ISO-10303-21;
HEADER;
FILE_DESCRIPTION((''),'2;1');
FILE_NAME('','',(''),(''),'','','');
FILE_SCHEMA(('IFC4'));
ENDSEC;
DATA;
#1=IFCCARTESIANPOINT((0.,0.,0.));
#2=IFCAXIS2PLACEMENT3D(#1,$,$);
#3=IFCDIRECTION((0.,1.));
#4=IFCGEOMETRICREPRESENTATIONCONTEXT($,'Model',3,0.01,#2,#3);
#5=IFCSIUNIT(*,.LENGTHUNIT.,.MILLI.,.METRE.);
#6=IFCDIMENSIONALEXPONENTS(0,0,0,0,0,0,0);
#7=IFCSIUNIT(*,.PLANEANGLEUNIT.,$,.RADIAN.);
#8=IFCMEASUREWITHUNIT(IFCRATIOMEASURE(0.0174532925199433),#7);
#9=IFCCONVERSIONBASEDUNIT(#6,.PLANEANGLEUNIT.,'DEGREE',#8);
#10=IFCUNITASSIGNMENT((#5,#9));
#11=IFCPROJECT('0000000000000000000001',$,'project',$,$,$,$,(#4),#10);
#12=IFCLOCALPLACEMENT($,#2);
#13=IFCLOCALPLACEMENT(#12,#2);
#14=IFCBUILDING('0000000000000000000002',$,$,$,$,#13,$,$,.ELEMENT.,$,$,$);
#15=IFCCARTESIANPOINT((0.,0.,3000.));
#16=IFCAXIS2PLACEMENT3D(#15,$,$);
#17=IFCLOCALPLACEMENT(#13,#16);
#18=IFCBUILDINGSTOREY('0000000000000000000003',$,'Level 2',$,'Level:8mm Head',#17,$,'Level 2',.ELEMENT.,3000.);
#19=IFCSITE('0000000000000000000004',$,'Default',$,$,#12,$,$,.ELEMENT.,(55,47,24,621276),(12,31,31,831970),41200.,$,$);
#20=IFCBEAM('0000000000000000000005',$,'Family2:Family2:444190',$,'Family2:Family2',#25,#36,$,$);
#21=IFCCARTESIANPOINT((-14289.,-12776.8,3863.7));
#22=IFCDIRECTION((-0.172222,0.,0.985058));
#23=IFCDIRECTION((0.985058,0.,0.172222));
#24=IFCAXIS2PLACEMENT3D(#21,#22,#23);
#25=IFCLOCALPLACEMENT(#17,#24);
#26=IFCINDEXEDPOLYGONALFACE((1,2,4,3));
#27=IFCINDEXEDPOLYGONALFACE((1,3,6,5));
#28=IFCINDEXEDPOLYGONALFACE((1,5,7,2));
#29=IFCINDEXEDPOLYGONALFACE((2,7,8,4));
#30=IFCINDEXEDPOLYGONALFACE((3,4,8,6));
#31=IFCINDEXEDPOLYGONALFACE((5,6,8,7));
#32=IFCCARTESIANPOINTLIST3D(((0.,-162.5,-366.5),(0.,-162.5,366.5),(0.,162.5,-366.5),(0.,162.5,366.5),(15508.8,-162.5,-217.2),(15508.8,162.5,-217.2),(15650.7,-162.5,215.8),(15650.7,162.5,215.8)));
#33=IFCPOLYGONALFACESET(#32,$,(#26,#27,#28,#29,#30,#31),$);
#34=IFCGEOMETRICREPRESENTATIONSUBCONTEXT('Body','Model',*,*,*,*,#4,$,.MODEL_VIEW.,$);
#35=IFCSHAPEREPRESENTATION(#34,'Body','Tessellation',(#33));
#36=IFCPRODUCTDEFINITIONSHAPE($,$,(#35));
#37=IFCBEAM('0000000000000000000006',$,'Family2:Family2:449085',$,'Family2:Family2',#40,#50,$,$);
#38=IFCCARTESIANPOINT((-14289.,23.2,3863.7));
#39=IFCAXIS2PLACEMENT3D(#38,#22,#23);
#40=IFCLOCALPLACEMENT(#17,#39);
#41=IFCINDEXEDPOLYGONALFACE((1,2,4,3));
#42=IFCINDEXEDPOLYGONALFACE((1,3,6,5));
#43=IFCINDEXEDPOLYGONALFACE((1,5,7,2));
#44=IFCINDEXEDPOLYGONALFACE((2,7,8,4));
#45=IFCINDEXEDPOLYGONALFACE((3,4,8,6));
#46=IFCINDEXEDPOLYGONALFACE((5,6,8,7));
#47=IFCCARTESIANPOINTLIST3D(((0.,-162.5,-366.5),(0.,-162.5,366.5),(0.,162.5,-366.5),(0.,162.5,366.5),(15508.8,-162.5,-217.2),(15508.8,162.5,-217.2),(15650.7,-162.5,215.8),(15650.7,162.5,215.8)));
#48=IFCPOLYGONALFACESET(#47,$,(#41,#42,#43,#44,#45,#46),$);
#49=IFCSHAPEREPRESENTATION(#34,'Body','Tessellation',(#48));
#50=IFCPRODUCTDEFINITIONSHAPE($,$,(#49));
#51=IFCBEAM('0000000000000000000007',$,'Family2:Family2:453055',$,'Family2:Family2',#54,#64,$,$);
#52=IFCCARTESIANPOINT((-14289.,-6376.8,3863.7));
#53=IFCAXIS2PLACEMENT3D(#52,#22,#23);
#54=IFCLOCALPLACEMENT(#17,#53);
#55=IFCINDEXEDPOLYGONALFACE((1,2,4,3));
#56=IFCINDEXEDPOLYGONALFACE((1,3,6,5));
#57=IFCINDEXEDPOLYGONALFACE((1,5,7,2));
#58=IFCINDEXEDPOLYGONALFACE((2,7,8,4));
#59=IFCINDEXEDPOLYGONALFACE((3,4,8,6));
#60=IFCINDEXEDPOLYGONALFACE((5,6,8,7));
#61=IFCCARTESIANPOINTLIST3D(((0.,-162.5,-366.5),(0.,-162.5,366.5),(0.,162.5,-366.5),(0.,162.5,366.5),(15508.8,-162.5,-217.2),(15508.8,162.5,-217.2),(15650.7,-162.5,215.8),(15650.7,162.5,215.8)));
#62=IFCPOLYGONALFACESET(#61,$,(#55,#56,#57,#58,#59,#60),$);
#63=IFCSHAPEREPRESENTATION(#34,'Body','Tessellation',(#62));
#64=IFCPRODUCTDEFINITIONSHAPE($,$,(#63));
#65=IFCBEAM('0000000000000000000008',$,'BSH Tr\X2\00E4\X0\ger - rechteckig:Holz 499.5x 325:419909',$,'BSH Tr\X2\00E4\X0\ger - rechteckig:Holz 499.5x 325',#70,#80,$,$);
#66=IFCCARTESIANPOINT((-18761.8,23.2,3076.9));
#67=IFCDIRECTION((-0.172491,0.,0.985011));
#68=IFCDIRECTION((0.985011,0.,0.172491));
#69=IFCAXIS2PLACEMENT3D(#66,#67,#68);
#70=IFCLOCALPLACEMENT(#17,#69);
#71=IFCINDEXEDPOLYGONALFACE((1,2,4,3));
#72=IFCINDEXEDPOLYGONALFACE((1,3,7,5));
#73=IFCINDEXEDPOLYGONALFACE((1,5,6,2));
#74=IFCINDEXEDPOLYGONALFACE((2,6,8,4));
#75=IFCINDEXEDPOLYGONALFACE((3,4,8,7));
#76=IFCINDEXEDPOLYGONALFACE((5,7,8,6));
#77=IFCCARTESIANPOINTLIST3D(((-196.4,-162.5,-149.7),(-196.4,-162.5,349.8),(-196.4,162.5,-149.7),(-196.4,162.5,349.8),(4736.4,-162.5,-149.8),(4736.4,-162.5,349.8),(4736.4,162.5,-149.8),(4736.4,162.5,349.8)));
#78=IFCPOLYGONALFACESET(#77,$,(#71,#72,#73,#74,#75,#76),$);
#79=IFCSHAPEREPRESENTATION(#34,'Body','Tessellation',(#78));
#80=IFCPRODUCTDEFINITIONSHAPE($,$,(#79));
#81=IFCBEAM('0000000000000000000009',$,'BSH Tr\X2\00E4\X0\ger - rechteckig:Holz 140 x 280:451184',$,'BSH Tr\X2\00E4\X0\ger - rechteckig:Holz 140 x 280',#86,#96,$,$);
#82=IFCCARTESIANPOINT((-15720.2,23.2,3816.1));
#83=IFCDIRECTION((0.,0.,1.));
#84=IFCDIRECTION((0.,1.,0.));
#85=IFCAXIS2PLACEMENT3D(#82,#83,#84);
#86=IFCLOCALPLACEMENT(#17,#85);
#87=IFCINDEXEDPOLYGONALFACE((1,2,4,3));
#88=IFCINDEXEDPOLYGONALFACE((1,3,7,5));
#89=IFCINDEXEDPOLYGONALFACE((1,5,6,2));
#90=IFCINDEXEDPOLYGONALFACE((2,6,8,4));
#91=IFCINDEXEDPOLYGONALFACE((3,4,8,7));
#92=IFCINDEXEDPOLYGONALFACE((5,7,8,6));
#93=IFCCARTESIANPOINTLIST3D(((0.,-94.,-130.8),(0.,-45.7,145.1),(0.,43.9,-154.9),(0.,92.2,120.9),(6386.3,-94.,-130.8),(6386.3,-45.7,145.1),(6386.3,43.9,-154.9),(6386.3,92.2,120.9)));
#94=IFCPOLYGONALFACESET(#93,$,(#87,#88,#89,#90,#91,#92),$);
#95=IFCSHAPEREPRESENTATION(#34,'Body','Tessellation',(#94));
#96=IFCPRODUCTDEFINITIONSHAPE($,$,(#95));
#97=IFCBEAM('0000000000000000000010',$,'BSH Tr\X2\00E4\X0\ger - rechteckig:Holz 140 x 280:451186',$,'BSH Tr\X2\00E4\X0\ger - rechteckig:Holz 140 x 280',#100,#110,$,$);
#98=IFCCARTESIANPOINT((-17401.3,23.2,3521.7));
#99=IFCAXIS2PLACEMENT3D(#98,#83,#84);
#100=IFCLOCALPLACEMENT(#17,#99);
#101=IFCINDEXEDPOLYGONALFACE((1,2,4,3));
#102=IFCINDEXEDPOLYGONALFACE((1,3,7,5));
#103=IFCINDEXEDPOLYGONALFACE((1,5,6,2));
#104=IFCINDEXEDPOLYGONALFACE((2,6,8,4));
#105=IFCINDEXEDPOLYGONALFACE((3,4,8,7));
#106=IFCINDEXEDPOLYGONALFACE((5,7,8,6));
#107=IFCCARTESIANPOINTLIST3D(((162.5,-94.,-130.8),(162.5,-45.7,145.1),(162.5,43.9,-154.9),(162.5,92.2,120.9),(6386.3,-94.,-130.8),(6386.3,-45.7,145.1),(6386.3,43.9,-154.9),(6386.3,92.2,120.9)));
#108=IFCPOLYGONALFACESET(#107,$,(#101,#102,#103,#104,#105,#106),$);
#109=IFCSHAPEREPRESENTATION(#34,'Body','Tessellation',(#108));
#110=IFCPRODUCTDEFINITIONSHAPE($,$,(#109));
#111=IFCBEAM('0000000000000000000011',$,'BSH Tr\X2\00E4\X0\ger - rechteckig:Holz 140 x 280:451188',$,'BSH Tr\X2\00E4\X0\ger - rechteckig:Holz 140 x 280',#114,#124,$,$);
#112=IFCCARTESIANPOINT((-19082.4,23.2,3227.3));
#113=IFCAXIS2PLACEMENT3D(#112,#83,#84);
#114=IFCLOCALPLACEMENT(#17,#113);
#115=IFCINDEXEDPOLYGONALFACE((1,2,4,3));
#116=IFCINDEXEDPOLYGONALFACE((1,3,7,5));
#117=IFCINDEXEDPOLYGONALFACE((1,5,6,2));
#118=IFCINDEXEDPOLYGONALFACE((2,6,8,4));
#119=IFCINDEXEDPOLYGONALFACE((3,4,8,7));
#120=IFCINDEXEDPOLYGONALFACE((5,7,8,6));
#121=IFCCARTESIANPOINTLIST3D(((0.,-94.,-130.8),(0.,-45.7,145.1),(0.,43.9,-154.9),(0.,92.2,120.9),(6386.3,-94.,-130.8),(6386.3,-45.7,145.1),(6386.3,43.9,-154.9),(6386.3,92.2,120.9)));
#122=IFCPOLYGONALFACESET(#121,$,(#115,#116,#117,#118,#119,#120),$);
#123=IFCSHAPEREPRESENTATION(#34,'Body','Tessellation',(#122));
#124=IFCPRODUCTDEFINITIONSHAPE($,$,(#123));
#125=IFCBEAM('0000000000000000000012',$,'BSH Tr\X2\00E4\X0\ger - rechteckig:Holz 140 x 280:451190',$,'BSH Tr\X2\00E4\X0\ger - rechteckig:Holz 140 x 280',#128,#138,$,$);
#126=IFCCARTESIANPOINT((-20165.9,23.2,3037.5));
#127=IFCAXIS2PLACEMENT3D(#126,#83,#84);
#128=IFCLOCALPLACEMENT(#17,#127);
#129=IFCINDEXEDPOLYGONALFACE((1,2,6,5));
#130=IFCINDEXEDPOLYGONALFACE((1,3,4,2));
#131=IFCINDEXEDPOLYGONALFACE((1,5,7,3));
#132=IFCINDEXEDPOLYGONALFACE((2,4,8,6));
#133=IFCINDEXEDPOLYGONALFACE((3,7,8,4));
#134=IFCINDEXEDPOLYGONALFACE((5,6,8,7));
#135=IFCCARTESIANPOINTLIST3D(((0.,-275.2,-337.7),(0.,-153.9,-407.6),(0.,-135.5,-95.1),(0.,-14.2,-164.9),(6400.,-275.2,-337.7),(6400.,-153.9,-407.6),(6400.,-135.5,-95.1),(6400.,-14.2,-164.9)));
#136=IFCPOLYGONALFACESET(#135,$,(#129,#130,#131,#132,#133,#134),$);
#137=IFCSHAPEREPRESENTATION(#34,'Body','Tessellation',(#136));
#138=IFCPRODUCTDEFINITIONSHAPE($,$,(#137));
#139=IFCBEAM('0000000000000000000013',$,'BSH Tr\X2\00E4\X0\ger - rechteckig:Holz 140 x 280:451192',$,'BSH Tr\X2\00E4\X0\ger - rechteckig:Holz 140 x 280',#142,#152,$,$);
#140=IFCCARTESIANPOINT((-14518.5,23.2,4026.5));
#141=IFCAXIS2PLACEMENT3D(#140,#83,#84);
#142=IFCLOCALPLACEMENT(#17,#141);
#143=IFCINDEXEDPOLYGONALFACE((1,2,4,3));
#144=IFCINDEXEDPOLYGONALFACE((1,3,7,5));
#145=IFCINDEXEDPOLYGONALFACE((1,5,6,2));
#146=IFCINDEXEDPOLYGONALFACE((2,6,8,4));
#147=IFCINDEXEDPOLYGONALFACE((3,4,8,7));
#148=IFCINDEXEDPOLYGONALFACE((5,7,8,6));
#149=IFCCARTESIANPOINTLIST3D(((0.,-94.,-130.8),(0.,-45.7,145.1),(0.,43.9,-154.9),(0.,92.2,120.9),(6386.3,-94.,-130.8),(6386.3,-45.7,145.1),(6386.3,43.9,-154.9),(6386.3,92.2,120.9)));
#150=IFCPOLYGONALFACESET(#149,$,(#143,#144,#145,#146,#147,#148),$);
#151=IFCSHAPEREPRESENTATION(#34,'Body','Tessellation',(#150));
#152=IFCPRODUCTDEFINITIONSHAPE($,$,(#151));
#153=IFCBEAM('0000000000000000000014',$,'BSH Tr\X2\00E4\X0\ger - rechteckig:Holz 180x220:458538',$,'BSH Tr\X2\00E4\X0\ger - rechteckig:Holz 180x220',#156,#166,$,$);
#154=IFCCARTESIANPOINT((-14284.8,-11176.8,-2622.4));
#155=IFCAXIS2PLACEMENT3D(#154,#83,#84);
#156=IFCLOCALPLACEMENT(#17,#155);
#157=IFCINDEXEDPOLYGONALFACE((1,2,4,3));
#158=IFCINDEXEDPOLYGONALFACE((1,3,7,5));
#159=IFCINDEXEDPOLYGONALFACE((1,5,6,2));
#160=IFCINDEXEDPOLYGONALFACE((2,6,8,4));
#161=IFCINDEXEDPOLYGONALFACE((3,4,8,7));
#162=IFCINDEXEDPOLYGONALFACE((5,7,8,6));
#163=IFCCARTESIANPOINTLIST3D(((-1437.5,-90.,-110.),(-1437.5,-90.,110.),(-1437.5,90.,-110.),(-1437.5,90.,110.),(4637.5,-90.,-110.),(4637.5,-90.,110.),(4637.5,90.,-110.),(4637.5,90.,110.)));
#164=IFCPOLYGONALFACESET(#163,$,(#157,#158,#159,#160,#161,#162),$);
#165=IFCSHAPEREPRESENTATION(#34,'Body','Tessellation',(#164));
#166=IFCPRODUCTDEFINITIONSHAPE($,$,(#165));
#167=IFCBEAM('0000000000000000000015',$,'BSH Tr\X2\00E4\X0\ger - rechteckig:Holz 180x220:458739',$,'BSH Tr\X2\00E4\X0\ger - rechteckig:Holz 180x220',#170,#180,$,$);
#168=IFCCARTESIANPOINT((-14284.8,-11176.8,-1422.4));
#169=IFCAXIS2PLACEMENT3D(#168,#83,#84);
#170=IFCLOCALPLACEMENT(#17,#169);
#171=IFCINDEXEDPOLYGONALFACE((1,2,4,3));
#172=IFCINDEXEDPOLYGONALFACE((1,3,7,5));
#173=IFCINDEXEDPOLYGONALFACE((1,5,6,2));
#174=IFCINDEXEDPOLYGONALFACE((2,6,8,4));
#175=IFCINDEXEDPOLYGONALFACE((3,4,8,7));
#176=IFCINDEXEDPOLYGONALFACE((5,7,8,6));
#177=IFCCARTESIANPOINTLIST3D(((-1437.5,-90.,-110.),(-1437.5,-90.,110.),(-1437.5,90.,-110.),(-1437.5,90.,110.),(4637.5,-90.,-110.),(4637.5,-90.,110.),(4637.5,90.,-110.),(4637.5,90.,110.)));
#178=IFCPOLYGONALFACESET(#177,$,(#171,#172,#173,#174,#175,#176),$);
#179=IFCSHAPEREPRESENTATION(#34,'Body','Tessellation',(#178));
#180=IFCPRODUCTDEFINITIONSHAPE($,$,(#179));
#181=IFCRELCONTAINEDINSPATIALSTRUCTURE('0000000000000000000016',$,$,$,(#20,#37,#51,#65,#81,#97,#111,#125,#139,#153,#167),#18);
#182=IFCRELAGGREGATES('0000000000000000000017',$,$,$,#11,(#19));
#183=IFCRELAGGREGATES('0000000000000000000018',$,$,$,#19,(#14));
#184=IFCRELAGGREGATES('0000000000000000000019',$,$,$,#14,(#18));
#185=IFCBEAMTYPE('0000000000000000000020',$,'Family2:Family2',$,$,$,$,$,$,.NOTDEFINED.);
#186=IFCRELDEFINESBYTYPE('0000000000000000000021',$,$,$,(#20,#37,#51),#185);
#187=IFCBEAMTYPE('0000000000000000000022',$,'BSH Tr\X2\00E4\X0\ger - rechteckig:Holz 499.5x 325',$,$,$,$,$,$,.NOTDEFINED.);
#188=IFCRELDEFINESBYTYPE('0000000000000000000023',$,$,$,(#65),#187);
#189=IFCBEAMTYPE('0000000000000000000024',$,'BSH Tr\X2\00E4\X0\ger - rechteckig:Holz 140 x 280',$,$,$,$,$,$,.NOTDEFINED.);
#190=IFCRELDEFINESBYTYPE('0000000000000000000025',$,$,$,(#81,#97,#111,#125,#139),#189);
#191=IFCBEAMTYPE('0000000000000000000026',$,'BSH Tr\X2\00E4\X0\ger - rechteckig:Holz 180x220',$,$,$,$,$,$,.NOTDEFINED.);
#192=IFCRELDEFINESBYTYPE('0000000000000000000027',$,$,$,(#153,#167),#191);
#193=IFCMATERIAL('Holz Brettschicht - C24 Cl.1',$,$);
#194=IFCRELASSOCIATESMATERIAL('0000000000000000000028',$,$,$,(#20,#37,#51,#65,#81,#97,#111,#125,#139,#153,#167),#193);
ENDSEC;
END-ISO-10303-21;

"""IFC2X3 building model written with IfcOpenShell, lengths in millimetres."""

from ifc_helpers import new_model, entity, si_unit, converted_unit, direction, frame, frame_2d, origin, origin_2d_with_axis, place, context, subcontext, project, spatial, polyline, rectangle, extrude, clip, bounded_halfspace, material, type_object, element, save


model = new_model("IFC2X3")

# Units and contexts
model_context = context("Model", 3, precision=0.01, world=origin(), true_north=direction((0.0, 1.0)))
body_context = subcontext(model_context, "Body", "Model", "MODEL_VIEW")
ifc_project = project(units=[si_unit("LENGTHUNIT", "METRE", prefix="MILLI"), converted_unit("PLANEANGLEUNIT", "DEGREE", entity("IfcRatioMeasure", 0.0174532925199433), si_unit("PLANEANGLEUNIT", "RADIAN"), dimensions=[0, 0, 0, 0, 0, 0, 0])], contexts=[model_context])

# Site, building, storey
site_placement = place(None, origin())
site = spatial("IfcSite", under=ifc_project, at=site_placement, Name="Default", CompositionType="ELEMENT", RefLatitude=(55, 47, 24, 621276), RefLongitude=(12, 31, 31, 831970), RefElevation=41200.0)
building_placement = place(site_placement, origin())
building = spatial("IfcBuilding", under=site, at=building_placement, CompositionType="ELEMENT")
storey_placement = place(building_placement, frame((0.0, 0.0, 3000.0)))
storey = spatial("IfcBuildingStorey", under=building, at=storey_placement, Name="Level 2", ObjectType="Level:8mm Head", LongName="Level 2", CompositionType="ELEMENT", Elevation=3000.0)

# Beams
ifc_material = material(Name="Holz Brettschicht - C24 Cl.1")
beam_type_1 = type_object("IfcBeamType", Name="Family2:Family2", PredefinedType="NOTDEFINED")
beam_1_placement = place(storey_placement, frame((-14289.0, -12776.8, 3863.7), z_axis=(-0.172222, 0.0, 0.985058), x_axis=(0.985058, 0.0, 0.172222)))
element("IfcBeam", 1, at=beam_1_placement, inside=storey, type_object=beam_type_1, material=ifc_material, Name="Family2:Family2:444190", ObjectType="Family2:Family2", context=body_context, shape_type="Clipping", body=[
    clip(clip(clip(extrude(rectangle(XDim=733.0, YDim=325.0, at=frame_2d((0.0, 0.0), x_axis=(0.0, 1.0))), frame((0.0, 0.0, 0.0), z_axis=(1.0, 0.0, 0.0), x_axis=(0.0, 1.0, 0.0)), (0.0, 0.0, 1.0), 15650.7), bounded_halfspace(frame((0.0, 0.0, -366.5), z_axis=(0.009627, 0.0, -0.999954), x_axis=(0.0, 1.0, 0.0)), False, frame((0.0, 0.0, 0.0), z_axis=(1.0, 0.0, 0.0), x_axis=(0.0, 1.0, 0.0)), polyline([(-162.5, -366.5), (162.5, -366.5), (162.5, -217.2), (-162.5, -217.2), (-162.5, -366.5)]))), bounded_halfspace(frame((15700.1, 0.0, 366.5), z_axis=(0.95028, 0.0, -0.311395), x_axis=(0.311395, 0.0, 0.95028)), False, frame((0.0, 0.0, 0.0), z_axis=(1.0, 0.0, 0.0), x_axis=(0.0, 1.0, 0.0)), polyline([(-162.5, 215.8), (-162.5, -217.2), (162.5, -217.2), (162.5, 215.8), (-162.5, 215.8)]))), bounded_halfspace(frame((0.0, 0.0, 366.5), z_axis=(0.009627, 0.0, 0.999954), x_axis=(0.0, -1.0, 0.0)), False, frame((0.0, 0.0, 0.0), z_axis=(1.0, 0.0, 0.0), x_axis=(0.0, 1.0, 0.0)), polyline([(162.5, 366.5), (-162.5, 366.5), (-162.5, 215.8), (162.5, 215.8), (162.5, 366.5)]))),
])
beam_2_placement = place(storey_placement, frame((-14289.0, 23.2, 3863.7), z_axis=(-0.172222, 0.0, 0.985058), x_axis=(0.985058, 0.0, 0.172222)))
element("IfcBeam", 2, at=beam_2_placement, inside=storey, type_object=beam_type_1, material=ifc_material, Name="Family2:Family2:449085", ObjectType="Family2:Family2", context=body_context, shape_type="Clipping", body=[
    clip(clip(clip(extrude(rectangle(XDim=733.0, YDim=325.0, at=frame_2d((0.0, 0.0), x_axis=(0.0, 1.0))), frame((0.0, 0.0, 0.0), z_axis=(1.0, 0.0, 0.0), x_axis=(0.0, 1.0, 0.0)), (0.0, 0.0, 1.0), 15650.7), bounded_halfspace(frame((0.0, 0.0, -366.5), z_axis=(0.009627, 0.0, -0.999954), x_axis=(0.0, 1.0, 0.0)), False, frame((0.0, 0.0, 0.0), z_axis=(1.0, 0.0, 0.0), x_axis=(0.0, 1.0, 0.0)), polyline([(-162.5, -366.5), (162.5, -366.5), (162.5, -217.2), (-162.5, -217.2), (-162.5, -366.5)]))), bounded_halfspace(frame((15700.1, 0.0, 366.5), z_axis=(0.95028, 0.0, -0.311395), x_axis=(0.311395, 0.0, 0.95028)), False, frame((0.0, 0.0, 0.0), z_axis=(1.0, 0.0, 0.0), x_axis=(0.0, 1.0, 0.0)), polyline([(-162.5, 215.8), (-162.5, -217.2), (162.5, -217.2), (162.5, 215.8), (-162.5, 215.8)]))), bounded_halfspace(frame((0.0, 0.0, 366.5), z_axis=(0.009627, 0.0, 0.999954), x_axis=(0.0, -1.0, 0.0)), False, frame((0.0, 0.0, 0.0), z_axis=(1.0, 0.0, 0.0), x_axis=(0.0, 1.0, 0.0)), polyline([(162.5, 366.5), (-162.5, 366.5), (-162.5, 215.8), (162.5, 215.8), (162.5, 366.5)]))),
])
beam_3_placement = place(storey_placement, frame((-14289.0, -6376.8, 3863.7), z_axis=(-0.172222, 0.0, 0.985058), x_axis=(0.985058, 0.0, 0.172222)))
element("IfcBeam", 3, at=beam_3_placement, inside=storey, type_object=beam_type_1, material=ifc_material, Name="Family2:Family2:453055", ObjectType="Family2:Family2", context=body_context, shape_type="Clipping", body=[
    clip(clip(clip(extrude(rectangle(XDim=733.0, YDim=325.0, at=frame_2d((0.0, 0.0), x_axis=(0.0, 1.0))), frame((0.0, 0.0, 0.0), z_axis=(1.0, 0.0, 0.0), x_axis=(0.0, 1.0, 0.0)), (0.0, 0.0, 1.0), 15650.7), bounded_halfspace(frame((0.0, 0.0, -366.5), z_axis=(0.009627, 0.0, -0.999954), x_axis=(0.0, 1.0, 0.0)), False, frame((0.0, 0.0, 0.0), z_axis=(1.0, 0.0, 0.0), x_axis=(0.0, 1.0, 0.0)), polyline([(-162.5, -366.5), (162.5, -366.5), (162.5, -217.2), (-162.5, -217.2), (-162.5, -366.5)]))), bounded_halfspace(frame((15700.1, 0.0, 366.5), z_axis=(0.95028, 0.0, -0.311395), x_axis=(0.311395, 0.0, 0.95028)), False, frame((0.0, 0.0, 0.0), z_axis=(1.0, 0.0, 0.0), x_axis=(0.0, 1.0, 0.0)), polyline([(-162.5, 215.8), (-162.5, -217.2), (162.5, -217.2), (162.5, 215.8), (-162.5, 215.8)]))), bounded_halfspace(frame((0.0, 0.0, 366.5), z_axis=(0.009627, 0.0, 0.999954), x_axis=(0.0, -1.0, 0.0)), False, frame((0.0, 0.0, 0.0), z_axis=(1.0, 0.0, 0.0), x_axis=(0.0, 1.0, 0.0)), polyline([(162.5, 366.5), (-162.5, 366.5), (-162.5, 215.8), (162.5, 215.8), (162.5, 366.5)]))),
])
beam_type_2 = type_object("IfcBeamType", Name="BSH Träger - rechteckig:Holz 499.5x 325", PredefinedType="NOTDEFINED")
beam_4_placement = place(storey_placement, frame((-18761.8, 23.2, 3076.9), z_axis=(-0.172491, 0.0, 0.985011), x_axis=(0.985011, 0.0, 0.172491)))
element("IfcBeam", 4, at=beam_4_placement, inside=storey, type_object=beam_type_2, material=ifc_material, Name="BSH Träger - rechteckig:Holz 499.5x 325:419909", ObjectType="BSH Träger - rechteckig:Holz 499.5x 325", context=body_context, shape_type="SweptSolid", body=[
    extrude(rectangle(XDim=499.5, YDim=325.0, at=frame_2d((0.0, 0.0), x_axis=(1.0, 0.0))), frame((-196.4, 0.0, 100.0), z_axis=(1.0, 0.0, 0.0), x_axis=(0.0, 0.0, -1.0)), (0.0, 0.0, 1.0), 4932.8),
])
beam_type_3 = type_object("IfcBeamType", Name="BSH Träger - rechteckig:Holz 140 x 280", PredefinedType="NOTDEFINED")
beam_5_placement = place(storey_placement, frame((-15720.2, 23.2, 3816.1), z_axis=(0.0, 0.0, 1.0), x_axis=(0.0, 1.0, 0.0)))
element("IfcBeam", 5, at=beam_5_placement, inside=storey, type_object=beam_type_3, material=ifc_material, Name="BSH Träger - rechteckig:Holz 140 x 280:451184", ObjectType="BSH Träger - rechteckig:Holz 140 x 280", context=body_context, shape_type="SweptSolid", body=[
    extrude(rectangle(XDim=280.0, YDim=140.0, at=origin_2d_with_axis()), frame((0.0, -0.9, -4.9), z_axis=(1.0, 0.0, 0.0), x_axis=(0.0, 0.172491, 0.985011)), (0.0, 0.0, 1.0), 6386.3),
])
beam_6_placement = place(storey_placement, frame((-17401.3, 23.2, 3521.7), z_axis=(0.0, 0.0, 1.0), x_axis=(0.0, 1.0, 0.0)))
element("IfcBeam", 6, at=beam_6_placement, inside=storey, type_object=beam_type_3, material=ifc_material, Name="BSH Träger - rechteckig:Holz 140 x 280:451186", ObjectType="BSH Träger - rechteckig:Holz 140 x 280", context=body_context, shape_type="SweptSolid", body=[
    extrude(rectangle(XDim=280.0, YDim=140.0, at=origin_2d_with_axis()), frame((162.5, -0.9, -4.9), z_axis=(1.0, 0.0, 0.0), x_axis=(0.0, 0.172491, 0.985011)), (0.0, 0.0, 1.0), 6223.8),
])
beam_7_placement = place(storey_placement, frame((-19082.4, 23.2, 3227.3), z_axis=(0.0, 0.0, 1.0), x_axis=(0.0, 1.0, 0.0)))
element("IfcBeam", 7, at=beam_7_placement, inside=storey, type_object=beam_type_3, material=ifc_material, Name="BSH Träger - rechteckig:Holz 140 x 280:451188", ObjectType="BSH Träger - rechteckig:Holz 140 x 280", context=body_context, shape_type="SweptSolid", body=[
    extrude(rectangle(XDim=280.0, YDim=140.0, at=frame_2d((0.0, 0.0), x_axis=(1.0, 0.0))), frame((0.0, -0.9, -4.9), z_axis=(1.0, 0.0, 0.0), x_axis=(0.0, 0.172491, 0.985011)), (0.0, 0.0, 1.0), 6386.3),
])
beam_8_placement = place(storey_placement, frame((-20165.9, 23.2, 3037.5), z_axis=(0.0, 0.0, 1.0), x_axis=(0.0, 1.0, 0.0)))
element("IfcBeam", 8, at=beam_8_placement, inside=storey, type_object=beam_type_3, material=ifc_material, Name="BSH Träger - rechteckig:Holz 140 x 280:451190", ObjectType="BSH Träger - rechteckig:Holz 140 x 280", context=body_context, shape_type="SweptSolid", body=[
    extrude(rectangle(XDim=280.0, YDim=140.0, at=origin_2d_with_axis()), frame((0.0, -144.7, -251.3), z_axis=(1.0, 0.0, 0.0), x_axis=(0.0, 0.498982, 0.866612)), (0.0, 0.0, 1.0), 6400.0),
])
beam_9_placement = place(storey_placement, frame((-14518.5, 23.2, 4026.5), z_axis=(0.0, 0.0, 1.0), x_axis=(0.0, 1.0, 0.0)))
element("IfcBeam", 9, at=beam_9_placement, inside=storey, type_object=beam_type_3, material=ifc_material, Name="BSH Träger - rechteckig:Holz 140 x 280:451192", ObjectType="BSH Träger - rechteckig:Holz 140 x 280", context=body_context, shape_type="SweptSolid", body=[
    extrude(rectangle(XDim=280.0, YDim=140.0, at=origin_2d_with_axis()), frame((0.0, -0.9, -4.9), z_axis=(1.0, 0.0, 0.0), x_axis=(0.0, 0.172491, 0.985011)), (0.0, 0.0, 1.0), 6386.3),
])
beam_type_4 = type_object("IfcBeamType", Name="BSH Träger - rechteckig:Holz 180x220", PredefinedType="NOTDEFINED")
beam_10_placement = place(storey_placement, frame((-14284.8, -11176.8, -2622.4), z_axis=(0.0, 0.0, 1.0), x_axis=(0.0, 1.0, 0.0)))
element("IfcBeam", 10, at=beam_10_placement, inside=storey, type_object=beam_type_4, material=ifc_material, Name="BSH Träger - rechteckig:Holz 180x220:458538", ObjectType="BSH Träger - rechteckig:Holz 180x220", context=body_context, shape_type="SweptSolid", body=[
    extrude(rectangle(XDim=220.0, YDim=180.0, at=frame_2d((0.0, 0.0), x_axis=(1.0, 0.0))), frame((-1437.5, 0.0, 0.0), z_axis=(1.0, 0.0, 0.0), x_axis=(0.0, 0.0, -1.0)), (0.0, 0.0, 1.0), 6075.0),
])
beam_11_placement = place(storey_placement, frame((-14284.8, -11176.8, -1422.4), z_axis=(0.0, 0.0, 1.0), x_axis=(0.0, 1.0, 0.0)))
element("IfcBeam", 11, at=beam_11_placement, inside=storey, type_object=beam_type_4, material=ifc_material, Name="BSH Träger - rechteckig:Holz 180x220:458739", ObjectType="BSH Träger - rechteckig:Holz 180x220", context=body_context, shape_type="SweptSolid", body=[
    extrude(rectangle(XDim=220.0, YDim=180.0, at=frame_2d((0.0, 0.0), x_axis=(1.0, 0.0))), frame((-1437.5, 0.0, 0.0), z_axis=(1.0, 0.0, 0.0), x_axis=(0.0, 0.0, -1.0)), (0.0, 0.0, 1.0), 6075.0),
])

save(model, "model.ifc")
